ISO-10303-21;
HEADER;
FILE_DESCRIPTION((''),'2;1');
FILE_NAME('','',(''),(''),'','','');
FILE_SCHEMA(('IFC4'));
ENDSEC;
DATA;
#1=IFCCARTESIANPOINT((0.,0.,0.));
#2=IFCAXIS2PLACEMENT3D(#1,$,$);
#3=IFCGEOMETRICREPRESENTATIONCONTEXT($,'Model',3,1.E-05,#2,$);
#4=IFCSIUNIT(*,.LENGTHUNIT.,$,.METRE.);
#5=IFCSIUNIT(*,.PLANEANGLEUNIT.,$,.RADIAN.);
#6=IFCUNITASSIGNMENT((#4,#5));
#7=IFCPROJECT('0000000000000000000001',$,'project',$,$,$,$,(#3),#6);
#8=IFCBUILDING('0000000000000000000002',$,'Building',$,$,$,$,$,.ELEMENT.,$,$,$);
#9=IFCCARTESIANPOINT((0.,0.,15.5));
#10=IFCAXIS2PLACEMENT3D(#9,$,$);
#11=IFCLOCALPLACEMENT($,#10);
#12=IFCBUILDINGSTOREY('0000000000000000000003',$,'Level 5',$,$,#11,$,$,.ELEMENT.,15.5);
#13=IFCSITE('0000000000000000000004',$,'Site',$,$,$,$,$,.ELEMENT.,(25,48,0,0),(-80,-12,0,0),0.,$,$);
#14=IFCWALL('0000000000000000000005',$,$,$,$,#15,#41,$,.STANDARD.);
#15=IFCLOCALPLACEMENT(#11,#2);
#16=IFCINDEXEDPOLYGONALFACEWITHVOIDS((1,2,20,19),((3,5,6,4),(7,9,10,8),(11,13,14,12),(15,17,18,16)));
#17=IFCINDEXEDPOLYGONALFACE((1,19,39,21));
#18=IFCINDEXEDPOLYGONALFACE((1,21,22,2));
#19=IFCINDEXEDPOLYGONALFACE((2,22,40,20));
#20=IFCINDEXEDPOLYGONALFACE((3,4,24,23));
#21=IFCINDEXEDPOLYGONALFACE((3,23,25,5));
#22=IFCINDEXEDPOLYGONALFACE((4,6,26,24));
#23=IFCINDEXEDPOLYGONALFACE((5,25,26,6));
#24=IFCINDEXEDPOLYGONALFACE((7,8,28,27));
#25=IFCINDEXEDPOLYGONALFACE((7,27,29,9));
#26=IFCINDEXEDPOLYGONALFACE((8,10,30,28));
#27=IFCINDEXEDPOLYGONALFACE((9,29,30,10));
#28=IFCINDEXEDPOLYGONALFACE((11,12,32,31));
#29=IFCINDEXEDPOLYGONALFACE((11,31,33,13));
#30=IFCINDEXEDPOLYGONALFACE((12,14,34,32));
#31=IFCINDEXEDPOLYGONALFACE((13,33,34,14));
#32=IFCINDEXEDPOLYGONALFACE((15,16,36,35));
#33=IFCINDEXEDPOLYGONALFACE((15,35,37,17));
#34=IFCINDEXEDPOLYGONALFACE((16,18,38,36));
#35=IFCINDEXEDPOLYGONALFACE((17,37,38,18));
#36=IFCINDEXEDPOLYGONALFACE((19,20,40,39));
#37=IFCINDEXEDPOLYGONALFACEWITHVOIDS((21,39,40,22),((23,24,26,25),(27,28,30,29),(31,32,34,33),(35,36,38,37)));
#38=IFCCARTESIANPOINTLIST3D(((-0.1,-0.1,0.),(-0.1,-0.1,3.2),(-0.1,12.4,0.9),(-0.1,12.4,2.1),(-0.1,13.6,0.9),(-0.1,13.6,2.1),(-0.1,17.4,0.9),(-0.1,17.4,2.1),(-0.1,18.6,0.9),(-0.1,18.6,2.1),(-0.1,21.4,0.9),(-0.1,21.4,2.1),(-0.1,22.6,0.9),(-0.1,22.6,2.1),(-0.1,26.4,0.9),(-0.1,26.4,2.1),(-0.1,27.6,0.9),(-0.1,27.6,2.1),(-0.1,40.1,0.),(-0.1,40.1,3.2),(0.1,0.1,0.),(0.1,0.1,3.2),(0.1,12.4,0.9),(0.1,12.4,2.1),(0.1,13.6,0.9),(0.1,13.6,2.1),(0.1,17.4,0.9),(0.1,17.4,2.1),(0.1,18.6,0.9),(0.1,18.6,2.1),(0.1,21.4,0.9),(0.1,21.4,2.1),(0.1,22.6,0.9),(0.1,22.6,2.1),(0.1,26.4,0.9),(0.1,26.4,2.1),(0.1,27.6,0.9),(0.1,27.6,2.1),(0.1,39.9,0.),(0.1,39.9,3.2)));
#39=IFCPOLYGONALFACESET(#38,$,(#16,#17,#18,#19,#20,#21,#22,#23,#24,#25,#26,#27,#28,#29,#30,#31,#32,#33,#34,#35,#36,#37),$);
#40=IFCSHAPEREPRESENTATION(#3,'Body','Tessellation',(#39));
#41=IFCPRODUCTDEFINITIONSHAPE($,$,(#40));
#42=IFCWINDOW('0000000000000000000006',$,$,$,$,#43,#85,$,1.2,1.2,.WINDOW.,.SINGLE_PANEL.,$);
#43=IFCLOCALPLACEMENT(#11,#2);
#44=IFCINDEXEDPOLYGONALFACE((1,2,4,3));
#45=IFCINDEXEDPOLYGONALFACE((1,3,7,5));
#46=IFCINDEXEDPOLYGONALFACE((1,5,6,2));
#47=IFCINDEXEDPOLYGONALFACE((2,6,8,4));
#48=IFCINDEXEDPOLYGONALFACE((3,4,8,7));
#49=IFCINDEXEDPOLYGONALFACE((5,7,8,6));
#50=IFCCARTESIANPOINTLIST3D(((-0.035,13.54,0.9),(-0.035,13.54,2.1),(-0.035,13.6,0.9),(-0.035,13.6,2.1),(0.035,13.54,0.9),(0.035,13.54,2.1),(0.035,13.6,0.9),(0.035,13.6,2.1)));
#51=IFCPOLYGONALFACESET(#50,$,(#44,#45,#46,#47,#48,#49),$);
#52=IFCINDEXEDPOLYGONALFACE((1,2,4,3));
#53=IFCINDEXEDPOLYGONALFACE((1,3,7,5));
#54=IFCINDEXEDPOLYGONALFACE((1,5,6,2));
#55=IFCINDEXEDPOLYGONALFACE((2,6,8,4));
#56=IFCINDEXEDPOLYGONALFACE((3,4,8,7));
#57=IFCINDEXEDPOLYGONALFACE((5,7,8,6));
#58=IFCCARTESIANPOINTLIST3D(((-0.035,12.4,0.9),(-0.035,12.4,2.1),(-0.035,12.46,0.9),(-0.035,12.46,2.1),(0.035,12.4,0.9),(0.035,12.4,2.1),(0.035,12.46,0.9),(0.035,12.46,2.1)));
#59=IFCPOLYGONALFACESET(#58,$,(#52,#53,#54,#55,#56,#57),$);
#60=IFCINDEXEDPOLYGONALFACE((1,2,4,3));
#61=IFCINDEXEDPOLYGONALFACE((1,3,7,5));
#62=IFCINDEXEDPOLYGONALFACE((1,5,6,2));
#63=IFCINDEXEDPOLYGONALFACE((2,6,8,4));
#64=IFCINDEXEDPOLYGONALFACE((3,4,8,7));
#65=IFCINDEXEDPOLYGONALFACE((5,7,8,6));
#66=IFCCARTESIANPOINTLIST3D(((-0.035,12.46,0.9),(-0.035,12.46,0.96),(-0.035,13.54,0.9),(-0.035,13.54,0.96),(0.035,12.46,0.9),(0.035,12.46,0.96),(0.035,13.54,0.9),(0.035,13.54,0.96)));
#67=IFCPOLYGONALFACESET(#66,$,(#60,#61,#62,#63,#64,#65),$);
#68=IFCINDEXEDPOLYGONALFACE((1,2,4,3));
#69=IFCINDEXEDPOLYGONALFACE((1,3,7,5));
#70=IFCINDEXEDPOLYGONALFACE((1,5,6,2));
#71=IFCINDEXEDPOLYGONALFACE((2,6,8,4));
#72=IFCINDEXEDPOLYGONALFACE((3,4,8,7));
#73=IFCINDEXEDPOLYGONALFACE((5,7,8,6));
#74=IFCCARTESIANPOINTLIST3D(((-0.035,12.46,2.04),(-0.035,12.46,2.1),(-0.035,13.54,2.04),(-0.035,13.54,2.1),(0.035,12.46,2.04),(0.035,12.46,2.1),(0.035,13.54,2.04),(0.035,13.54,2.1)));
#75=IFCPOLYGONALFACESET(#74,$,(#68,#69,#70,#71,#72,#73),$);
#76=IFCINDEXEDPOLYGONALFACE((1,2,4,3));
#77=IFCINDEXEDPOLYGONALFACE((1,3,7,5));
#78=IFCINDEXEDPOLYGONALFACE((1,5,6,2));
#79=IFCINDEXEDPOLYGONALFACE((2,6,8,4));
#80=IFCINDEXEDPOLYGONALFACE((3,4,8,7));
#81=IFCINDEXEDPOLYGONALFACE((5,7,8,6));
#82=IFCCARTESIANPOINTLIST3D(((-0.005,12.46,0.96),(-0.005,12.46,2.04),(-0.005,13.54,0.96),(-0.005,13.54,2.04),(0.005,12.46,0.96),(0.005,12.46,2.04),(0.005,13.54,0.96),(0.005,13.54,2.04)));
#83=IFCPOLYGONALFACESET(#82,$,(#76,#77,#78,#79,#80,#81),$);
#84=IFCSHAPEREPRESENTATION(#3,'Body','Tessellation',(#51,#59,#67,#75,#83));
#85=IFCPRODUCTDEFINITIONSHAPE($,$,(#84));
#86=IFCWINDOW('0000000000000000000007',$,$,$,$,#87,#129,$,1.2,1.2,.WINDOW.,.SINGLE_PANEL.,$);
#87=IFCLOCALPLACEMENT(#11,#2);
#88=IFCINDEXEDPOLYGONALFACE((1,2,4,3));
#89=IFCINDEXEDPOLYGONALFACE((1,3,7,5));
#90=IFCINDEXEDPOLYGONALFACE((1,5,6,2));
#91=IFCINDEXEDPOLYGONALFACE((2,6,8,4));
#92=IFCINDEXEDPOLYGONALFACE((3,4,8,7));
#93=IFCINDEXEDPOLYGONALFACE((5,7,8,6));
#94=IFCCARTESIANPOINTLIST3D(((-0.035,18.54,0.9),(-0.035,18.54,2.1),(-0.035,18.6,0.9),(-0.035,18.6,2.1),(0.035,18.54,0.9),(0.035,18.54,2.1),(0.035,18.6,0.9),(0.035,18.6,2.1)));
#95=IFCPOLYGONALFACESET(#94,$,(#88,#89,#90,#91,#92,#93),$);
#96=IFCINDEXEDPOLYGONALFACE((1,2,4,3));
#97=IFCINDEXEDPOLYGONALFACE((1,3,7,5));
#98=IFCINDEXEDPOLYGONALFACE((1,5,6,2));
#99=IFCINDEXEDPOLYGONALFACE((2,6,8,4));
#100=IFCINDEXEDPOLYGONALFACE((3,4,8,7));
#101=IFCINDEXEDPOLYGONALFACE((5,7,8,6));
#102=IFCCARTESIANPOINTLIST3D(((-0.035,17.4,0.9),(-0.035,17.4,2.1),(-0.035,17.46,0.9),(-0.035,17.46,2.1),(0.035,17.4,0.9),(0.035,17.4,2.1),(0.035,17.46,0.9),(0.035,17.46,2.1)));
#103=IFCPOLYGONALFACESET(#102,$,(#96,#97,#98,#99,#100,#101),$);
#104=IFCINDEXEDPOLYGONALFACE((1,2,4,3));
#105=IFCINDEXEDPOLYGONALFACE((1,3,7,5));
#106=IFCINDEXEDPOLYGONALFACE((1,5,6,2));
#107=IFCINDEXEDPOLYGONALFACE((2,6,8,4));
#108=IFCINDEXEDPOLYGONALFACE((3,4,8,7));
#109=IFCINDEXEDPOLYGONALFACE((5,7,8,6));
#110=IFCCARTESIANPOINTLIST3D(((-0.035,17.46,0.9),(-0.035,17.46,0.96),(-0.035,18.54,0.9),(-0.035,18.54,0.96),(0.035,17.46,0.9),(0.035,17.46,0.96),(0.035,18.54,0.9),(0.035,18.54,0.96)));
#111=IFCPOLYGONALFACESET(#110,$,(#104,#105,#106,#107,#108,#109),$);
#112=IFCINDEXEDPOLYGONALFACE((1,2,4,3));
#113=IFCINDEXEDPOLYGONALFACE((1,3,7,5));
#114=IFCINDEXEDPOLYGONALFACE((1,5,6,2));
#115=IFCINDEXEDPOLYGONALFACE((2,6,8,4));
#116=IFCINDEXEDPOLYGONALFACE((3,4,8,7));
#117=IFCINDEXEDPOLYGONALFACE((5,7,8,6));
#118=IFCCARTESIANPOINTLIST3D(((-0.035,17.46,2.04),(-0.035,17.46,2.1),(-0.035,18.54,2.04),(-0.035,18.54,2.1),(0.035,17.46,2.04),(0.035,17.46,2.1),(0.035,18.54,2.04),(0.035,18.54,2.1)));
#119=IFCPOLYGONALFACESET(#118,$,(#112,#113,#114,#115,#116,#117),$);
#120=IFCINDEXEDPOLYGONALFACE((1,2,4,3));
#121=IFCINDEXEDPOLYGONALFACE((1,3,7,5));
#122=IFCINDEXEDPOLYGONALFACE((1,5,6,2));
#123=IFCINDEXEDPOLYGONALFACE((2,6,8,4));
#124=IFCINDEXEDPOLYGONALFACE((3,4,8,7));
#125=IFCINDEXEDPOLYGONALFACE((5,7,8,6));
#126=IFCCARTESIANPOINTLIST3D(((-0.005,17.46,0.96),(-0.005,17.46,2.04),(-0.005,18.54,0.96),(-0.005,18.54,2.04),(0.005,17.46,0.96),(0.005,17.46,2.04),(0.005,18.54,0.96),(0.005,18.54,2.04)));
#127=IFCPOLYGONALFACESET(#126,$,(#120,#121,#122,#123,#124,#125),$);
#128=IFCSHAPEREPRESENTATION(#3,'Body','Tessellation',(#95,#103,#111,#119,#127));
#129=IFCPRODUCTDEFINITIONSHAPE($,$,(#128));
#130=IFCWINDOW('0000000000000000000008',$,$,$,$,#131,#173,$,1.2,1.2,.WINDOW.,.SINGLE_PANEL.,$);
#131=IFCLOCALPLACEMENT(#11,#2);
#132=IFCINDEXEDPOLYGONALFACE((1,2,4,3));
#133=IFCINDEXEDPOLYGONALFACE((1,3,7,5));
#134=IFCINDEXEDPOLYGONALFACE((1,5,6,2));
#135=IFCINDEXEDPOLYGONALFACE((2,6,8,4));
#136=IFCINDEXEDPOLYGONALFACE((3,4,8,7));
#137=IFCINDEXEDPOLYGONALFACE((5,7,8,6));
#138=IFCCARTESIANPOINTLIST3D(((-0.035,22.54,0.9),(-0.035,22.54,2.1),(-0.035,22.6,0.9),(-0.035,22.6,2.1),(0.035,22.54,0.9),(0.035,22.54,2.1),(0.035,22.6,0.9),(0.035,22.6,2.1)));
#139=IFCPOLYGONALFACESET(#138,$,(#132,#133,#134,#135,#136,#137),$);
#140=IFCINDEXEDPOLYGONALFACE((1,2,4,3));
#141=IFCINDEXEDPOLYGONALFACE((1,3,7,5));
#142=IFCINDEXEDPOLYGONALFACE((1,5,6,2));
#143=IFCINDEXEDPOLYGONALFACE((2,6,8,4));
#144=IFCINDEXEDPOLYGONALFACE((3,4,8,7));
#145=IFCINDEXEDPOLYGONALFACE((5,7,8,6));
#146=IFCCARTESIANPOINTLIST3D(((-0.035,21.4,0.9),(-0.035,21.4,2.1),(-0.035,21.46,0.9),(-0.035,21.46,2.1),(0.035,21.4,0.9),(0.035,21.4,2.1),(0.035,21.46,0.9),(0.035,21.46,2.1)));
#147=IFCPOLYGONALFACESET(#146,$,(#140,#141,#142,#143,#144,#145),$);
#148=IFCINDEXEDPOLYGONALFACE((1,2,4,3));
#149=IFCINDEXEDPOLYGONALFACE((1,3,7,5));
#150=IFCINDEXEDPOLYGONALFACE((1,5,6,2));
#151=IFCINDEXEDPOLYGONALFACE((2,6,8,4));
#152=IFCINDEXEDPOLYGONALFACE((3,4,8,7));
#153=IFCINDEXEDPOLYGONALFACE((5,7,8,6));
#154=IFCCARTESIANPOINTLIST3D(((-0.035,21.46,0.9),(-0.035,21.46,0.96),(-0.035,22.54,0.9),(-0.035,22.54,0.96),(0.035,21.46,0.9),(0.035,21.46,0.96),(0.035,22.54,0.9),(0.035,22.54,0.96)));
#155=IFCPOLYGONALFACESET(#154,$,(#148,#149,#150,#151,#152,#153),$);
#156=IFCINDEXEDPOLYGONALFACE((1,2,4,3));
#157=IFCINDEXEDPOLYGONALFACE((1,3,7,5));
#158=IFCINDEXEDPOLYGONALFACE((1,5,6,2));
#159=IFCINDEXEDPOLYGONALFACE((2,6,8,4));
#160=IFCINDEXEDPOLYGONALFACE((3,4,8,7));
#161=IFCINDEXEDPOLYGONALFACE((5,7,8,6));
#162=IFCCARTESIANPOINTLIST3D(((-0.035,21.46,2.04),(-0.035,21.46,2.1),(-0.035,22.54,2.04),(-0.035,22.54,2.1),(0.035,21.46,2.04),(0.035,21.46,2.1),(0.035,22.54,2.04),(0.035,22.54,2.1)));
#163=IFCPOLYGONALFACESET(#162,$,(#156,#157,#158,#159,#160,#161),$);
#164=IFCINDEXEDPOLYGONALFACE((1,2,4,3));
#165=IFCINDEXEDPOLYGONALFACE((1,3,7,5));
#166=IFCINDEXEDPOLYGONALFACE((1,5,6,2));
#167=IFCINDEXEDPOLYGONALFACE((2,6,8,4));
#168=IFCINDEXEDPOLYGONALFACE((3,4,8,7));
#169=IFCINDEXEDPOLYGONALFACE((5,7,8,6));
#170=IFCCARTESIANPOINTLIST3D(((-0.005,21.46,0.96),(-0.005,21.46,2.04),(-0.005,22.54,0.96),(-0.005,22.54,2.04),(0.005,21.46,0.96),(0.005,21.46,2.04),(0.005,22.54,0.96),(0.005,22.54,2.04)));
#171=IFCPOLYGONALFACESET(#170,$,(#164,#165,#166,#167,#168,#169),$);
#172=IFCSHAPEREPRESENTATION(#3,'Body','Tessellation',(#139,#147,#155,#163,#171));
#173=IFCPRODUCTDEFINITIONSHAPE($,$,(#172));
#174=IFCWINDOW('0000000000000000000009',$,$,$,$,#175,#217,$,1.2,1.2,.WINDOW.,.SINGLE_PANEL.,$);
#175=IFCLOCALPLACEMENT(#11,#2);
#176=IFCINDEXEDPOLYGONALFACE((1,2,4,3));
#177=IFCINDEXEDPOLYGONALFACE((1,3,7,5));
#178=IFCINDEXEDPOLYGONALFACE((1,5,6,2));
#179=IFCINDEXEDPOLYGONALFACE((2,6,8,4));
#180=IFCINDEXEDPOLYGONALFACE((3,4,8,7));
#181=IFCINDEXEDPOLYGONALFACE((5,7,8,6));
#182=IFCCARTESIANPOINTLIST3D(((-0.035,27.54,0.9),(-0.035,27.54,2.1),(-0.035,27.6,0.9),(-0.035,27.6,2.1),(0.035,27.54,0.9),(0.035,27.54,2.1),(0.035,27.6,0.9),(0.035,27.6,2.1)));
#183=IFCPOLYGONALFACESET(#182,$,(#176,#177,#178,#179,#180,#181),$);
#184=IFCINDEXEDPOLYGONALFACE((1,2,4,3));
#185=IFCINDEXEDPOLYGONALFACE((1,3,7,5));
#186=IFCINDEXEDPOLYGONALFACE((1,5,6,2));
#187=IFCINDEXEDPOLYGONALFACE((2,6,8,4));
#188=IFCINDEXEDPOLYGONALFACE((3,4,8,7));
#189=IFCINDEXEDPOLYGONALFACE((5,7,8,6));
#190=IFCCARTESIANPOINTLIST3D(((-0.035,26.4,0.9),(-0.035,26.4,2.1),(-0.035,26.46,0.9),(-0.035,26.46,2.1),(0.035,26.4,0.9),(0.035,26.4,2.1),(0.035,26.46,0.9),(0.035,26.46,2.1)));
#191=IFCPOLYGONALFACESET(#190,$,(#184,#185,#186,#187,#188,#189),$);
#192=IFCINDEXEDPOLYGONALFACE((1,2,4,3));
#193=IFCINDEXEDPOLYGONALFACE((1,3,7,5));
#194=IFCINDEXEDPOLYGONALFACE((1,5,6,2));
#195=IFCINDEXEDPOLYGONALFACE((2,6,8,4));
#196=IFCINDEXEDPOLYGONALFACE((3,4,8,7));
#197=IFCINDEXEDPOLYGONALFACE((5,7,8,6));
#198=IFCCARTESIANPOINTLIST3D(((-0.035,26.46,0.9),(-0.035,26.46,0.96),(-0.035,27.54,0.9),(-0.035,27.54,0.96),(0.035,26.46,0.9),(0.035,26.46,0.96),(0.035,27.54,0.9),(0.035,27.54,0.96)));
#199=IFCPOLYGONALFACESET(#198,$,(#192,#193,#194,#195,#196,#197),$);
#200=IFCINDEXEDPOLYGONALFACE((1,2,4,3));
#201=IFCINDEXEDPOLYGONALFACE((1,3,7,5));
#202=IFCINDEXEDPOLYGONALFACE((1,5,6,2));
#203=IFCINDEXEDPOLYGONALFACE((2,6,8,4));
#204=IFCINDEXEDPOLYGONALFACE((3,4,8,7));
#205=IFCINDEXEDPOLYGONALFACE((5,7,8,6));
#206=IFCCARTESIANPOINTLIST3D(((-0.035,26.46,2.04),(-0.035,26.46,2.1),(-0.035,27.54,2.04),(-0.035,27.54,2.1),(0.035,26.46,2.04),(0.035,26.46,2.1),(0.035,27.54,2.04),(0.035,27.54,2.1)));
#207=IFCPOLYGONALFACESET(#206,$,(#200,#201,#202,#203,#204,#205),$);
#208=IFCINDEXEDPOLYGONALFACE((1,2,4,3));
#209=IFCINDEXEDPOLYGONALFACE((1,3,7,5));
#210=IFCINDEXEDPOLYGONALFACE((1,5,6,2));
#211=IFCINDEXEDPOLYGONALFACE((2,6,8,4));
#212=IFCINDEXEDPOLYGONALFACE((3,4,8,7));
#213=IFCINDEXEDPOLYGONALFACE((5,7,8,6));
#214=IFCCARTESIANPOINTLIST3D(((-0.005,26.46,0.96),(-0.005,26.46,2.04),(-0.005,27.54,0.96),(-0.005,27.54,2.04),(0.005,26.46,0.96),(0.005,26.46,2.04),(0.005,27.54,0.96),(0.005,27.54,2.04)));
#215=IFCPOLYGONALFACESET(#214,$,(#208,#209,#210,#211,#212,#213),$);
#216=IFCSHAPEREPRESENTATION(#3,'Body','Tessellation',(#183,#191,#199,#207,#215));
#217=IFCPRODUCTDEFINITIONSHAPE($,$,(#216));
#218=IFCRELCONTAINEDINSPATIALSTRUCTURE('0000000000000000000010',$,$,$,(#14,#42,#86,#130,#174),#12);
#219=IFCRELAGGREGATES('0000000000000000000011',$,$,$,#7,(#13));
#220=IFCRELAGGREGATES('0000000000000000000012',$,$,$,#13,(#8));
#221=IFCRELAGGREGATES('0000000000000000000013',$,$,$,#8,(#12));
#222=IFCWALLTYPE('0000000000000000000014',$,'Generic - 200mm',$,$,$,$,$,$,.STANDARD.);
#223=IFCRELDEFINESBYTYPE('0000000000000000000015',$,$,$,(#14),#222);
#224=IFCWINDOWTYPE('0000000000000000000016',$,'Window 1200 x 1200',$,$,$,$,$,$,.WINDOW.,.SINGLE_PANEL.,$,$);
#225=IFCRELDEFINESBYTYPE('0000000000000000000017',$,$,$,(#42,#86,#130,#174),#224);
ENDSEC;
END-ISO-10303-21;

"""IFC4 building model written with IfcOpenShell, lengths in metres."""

from ifc_helpers import new_model, si_unit, frame, frame_2d, origin, origin_with_axes, origin_2d, place, context, project, spatial, polyline, rectangle, outline, extrude, type_object, element, fill, save


model = new_model("IFC4")

# Units and contexts
model_context = context("Model", 3, precision=1e-05, world=origin())
ifc_project = project(units=[si_unit("LENGTHUNIT", "METRE"), si_unit("PLANEANGLEUNIT", "RADIAN")], contexts=[model_context])

# Site, building, storey
site = spatial("IfcSite", under=ifc_project, Name="Site", CompositionType="ELEMENT", RefLatitude=(25, 48, 0, 0), RefLongitude=(-80, -12, 0, 0), RefElevation=0.0)
building = spatial("IfcBuilding", under=site, Name="Building", CompositionType="ELEMENT")
storey_placement = place(None, frame((0.0, 0.0, 15.5)))
storey = spatial("IfcBuildingStorey", under=building, at=storey_placement, Name="Level 5", CompositionType="ELEMENT", Elevation=15.5)

# Wall, openings, windows
wall_type = type_object("IfcWallType", Name="Generic - 200mm", PredefinedType="STANDARD")
wall_1_placement = place(None, frame((0.0, 40.0, 15.5), z_axis=(0.0, 0.0, 1.0), x_axis=(0.0, -1.0, 0.0)))
wall_1 = element("IfcWall", 1, at=wall_1_placement, inside=storey, type_object=wall_type, PredefinedType="STANDARD", context=model_context, shape_type="SweptSolid", body=[
    extrude(outline(polyline([(-0.1, -0.1), (40.1, -0.1), (39.9, 0.1), (0.1, 0.1), (-0.1, -0.1)])), origin(), (0.0, 0.0, 1.0), 3.2),
])
opening_1_placement = place(wall_1_placement, frame((27.0, 0.0, 0.9), z_axis=(0.0, 0.0, 1.0), x_axis=(1.0, 0.0, 0.0)))
opening_1 = element("IfcOpeningElement", 2, at=opening_1_placement, cuts=wall_1, PredefinedType="OPENING", context=model_context, shape_type="SweptSolid", body=[
    extrude(rectangle(XDim=1.2, YDim=0.202, at=origin_2d()), origin(), (0.0, 0.0, 1.0), 1.2),
])
opening_2_placement = place(wall_1_placement, frame((22.0, 0.0, 0.9), z_axis=(0.0, 0.0, 1.0), x_axis=(1.0, 0.0, 0.0)))
opening_2 = element("IfcOpeningElement", 3, at=opening_2_placement, cuts=wall_1, PredefinedType="OPENING", context=model_context, shape_type="SweptSolid", body=[
    extrude(rectangle(XDim=1.2, YDim=0.202, at=origin_2d()), origin(), (0.0, 0.0, 1.0), 1.2),
])
opening_3_placement = place(wall_1_placement, frame((18.0, 0.0, 0.9), z_axis=(0.0, 0.0, 1.0), x_axis=(1.0, 0.0, 0.0)))
opening_3 = element("IfcOpeningElement", 4, at=opening_3_placement, cuts=wall_1, PredefinedType="OPENING", context=model_context, shape_type="SweptSolid", body=[
    extrude(rectangle(XDim=1.2, YDim=0.202, at=origin_2d()), origin(), (0.0, 0.0, 1.0), 1.2),
])
opening_4_placement = place(wall_1_placement, frame((13.0, 0.0, 0.9), z_axis=(0.0, 0.0, 1.0), x_axis=(1.0, 0.0, 0.0)))
opening_4 = element("IfcOpeningElement", 5, at=opening_4_placement, cuts=wall_1, PredefinedType="OPENING", context=model_context, shape_type="SweptSolid", body=[
    extrude(rectangle(XDim=1.2, YDim=0.202, at=origin_2d()), origin(), (0.0, 0.0, 1.0), 1.2),
])
window_type = type_object("IfcWindowType", Name="Window 1200 x 1200", PartitioningType="SINGLE_PANEL", PredefinedType="WINDOW")
window_1_placement = place(opening_1_placement, origin_with_axes())
window_1 = element("IfcWindow", 6, at=window_1_placement, inside=storey, type_object=window_type, OverallHeight=1.2, OverallWidth=1.2, PartitioningType="SINGLE_PANEL", PredefinedType="WINDOW", context=model_context, shape_type="SweptSolid", body=[
    extrude(rectangle(XDim=0.06, YDim=0.07, at=frame_2d((-0.57, 0.0))), origin(), (0.0, 0.0, 1.0), 1.2),
    extrude(rectangle(XDim=0.06, YDim=0.07, at=frame_2d((0.57, 0.0))), origin(), (0.0, 0.0, 1.0), 1.2),
    extrude(rectangle(XDim=1.08, YDim=0.07, at=origin_2d()), origin(), (0.0, 0.0, 1.0), 0.06),
    extrude(rectangle(XDim=1.08, YDim=0.07, at=origin_2d()), frame((0.0, 0.0, 1.14)), (0.0, 0.0, 1.0), 0.06),
    extrude(rectangle(XDim=1.08, YDim=0.01, at=origin_2d()), frame((0.0, 0.0, 0.06)), (0.0, 0.0, 1.0), 1.08),
])
fill(opening_1, window_1)
window_2_placement = place(opening_2_placement, origin_with_axes())
window_2 = element("IfcWindow", 7, at=window_2_placement, inside=storey, type_object=window_type, OverallHeight=1.2, OverallWidth=1.2, PartitioningType="SINGLE_PANEL", PredefinedType="WINDOW", context=model_context, shape_type="SweptSolid", body=[
    extrude(rectangle(XDim=0.06, YDim=0.07, at=frame_2d((-0.57, 0.0))), origin(), (0.0, 0.0, 1.0), 1.2),
    extrude(rectangle(XDim=0.06, YDim=0.07, at=frame_2d((0.57, 0.0))), origin(), (0.0, 0.0, 1.0), 1.2),
    extrude(rectangle(XDim=1.08, YDim=0.07, at=origin_2d()), origin(), (0.0, 0.0, 1.0), 0.06),
    extrude(rectangle(XDim=1.08, YDim=0.07, at=origin_2d()), frame((0.0, 0.0, 1.14)), (0.0, 0.0, 1.0), 0.06),
    extrude(rectangle(XDim=1.08, YDim=0.01, at=origin_2d()), frame((0.0, 0.0, 0.06)), (0.0, 0.0, 1.0), 1.08),
])
fill(opening_2, window_2)
window_3_placement = place(opening_3_placement, origin_with_axes())
window_3 = element("IfcWindow", 8, at=window_3_placement, inside=storey, type_object=window_type, OverallHeight=1.2, OverallWidth=1.2, PartitioningType="SINGLE_PANEL", PredefinedType="WINDOW", context=model_context, shape_type="SweptSolid", body=[
    extrude(rectangle(XDim=0.06, YDim=0.07, at=frame_2d((-0.57, 0.0))), origin(), (0.0, 0.0, 1.0), 1.2),
    extrude(rectangle(XDim=0.06, YDim=0.07, at=frame_2d((0.57, 0.0))), origin(), (0.0, 0.0, 1.0), 1.2),
    extrude(rectangle(XDim=1.08, YDim=0.07, at=origin_2d()), origin(), (0.0, 0.0, 1.0), 0.06),
    extrude(rectangle(XDim=1.08, YDim=0.07, at=origin_2d()), frame((0.0, 0.0, 1.14)), (0.0, 0.0, 1.0), 0.06),
    extrude(rectangle(XDim=1.08, YDim=0.01, at=origin_2d()), frame((0.0, 0.0, 0.06)), (0.0, 0.0, 1.0), 1.08),
])
fill(opening_3, window_3)
window_4_placement = place(opening_4_placement, origin_with_axes())
window_4 = element("IfcWindow", 9, at=window_4_placement, inside=storey, type_object=window_type, OverallHeight=1.2, OverallWidth=1.2, PartitioningType="SINGLE_PANEL", PredefinedType="WINDOW", context=model_context, shape_type="SweptSolid", body=[
    extrude(rectangle(XDim=0.06, YDim=0.07, at=frame_2d((-0.57, 0.0))), origin(), (0.0, 0.0, 1.0), 1.2),
    extrude(rectangle(XDim=0.06, YDim=0.07, at=frame_2d((0.57, 0.0))), origin(), (0.0, 0.0, 1.0), 1.2),
    extrude(rectangle(XDim=1.08, YDim=0.07, at=origin_2d()), origin(), (0.0, 0.0, 1.0), 0.06),
    extrude(rectangle(XDim=1.08, YDim=0.07, at=origin_2d()), frame((0.0, 0.0, 1.14)), (0.0, 0.0, 1.0), 0.06),
    extrude(rectangle(XDim=1.08, YDim=0.01, at=origin_2d()), frame((0.0, 0.0, 0.06)), (0.0, 0.0, 1.0), 1.08),
])
fill(opening_4, window_4)

save(model, "model.ifc")
